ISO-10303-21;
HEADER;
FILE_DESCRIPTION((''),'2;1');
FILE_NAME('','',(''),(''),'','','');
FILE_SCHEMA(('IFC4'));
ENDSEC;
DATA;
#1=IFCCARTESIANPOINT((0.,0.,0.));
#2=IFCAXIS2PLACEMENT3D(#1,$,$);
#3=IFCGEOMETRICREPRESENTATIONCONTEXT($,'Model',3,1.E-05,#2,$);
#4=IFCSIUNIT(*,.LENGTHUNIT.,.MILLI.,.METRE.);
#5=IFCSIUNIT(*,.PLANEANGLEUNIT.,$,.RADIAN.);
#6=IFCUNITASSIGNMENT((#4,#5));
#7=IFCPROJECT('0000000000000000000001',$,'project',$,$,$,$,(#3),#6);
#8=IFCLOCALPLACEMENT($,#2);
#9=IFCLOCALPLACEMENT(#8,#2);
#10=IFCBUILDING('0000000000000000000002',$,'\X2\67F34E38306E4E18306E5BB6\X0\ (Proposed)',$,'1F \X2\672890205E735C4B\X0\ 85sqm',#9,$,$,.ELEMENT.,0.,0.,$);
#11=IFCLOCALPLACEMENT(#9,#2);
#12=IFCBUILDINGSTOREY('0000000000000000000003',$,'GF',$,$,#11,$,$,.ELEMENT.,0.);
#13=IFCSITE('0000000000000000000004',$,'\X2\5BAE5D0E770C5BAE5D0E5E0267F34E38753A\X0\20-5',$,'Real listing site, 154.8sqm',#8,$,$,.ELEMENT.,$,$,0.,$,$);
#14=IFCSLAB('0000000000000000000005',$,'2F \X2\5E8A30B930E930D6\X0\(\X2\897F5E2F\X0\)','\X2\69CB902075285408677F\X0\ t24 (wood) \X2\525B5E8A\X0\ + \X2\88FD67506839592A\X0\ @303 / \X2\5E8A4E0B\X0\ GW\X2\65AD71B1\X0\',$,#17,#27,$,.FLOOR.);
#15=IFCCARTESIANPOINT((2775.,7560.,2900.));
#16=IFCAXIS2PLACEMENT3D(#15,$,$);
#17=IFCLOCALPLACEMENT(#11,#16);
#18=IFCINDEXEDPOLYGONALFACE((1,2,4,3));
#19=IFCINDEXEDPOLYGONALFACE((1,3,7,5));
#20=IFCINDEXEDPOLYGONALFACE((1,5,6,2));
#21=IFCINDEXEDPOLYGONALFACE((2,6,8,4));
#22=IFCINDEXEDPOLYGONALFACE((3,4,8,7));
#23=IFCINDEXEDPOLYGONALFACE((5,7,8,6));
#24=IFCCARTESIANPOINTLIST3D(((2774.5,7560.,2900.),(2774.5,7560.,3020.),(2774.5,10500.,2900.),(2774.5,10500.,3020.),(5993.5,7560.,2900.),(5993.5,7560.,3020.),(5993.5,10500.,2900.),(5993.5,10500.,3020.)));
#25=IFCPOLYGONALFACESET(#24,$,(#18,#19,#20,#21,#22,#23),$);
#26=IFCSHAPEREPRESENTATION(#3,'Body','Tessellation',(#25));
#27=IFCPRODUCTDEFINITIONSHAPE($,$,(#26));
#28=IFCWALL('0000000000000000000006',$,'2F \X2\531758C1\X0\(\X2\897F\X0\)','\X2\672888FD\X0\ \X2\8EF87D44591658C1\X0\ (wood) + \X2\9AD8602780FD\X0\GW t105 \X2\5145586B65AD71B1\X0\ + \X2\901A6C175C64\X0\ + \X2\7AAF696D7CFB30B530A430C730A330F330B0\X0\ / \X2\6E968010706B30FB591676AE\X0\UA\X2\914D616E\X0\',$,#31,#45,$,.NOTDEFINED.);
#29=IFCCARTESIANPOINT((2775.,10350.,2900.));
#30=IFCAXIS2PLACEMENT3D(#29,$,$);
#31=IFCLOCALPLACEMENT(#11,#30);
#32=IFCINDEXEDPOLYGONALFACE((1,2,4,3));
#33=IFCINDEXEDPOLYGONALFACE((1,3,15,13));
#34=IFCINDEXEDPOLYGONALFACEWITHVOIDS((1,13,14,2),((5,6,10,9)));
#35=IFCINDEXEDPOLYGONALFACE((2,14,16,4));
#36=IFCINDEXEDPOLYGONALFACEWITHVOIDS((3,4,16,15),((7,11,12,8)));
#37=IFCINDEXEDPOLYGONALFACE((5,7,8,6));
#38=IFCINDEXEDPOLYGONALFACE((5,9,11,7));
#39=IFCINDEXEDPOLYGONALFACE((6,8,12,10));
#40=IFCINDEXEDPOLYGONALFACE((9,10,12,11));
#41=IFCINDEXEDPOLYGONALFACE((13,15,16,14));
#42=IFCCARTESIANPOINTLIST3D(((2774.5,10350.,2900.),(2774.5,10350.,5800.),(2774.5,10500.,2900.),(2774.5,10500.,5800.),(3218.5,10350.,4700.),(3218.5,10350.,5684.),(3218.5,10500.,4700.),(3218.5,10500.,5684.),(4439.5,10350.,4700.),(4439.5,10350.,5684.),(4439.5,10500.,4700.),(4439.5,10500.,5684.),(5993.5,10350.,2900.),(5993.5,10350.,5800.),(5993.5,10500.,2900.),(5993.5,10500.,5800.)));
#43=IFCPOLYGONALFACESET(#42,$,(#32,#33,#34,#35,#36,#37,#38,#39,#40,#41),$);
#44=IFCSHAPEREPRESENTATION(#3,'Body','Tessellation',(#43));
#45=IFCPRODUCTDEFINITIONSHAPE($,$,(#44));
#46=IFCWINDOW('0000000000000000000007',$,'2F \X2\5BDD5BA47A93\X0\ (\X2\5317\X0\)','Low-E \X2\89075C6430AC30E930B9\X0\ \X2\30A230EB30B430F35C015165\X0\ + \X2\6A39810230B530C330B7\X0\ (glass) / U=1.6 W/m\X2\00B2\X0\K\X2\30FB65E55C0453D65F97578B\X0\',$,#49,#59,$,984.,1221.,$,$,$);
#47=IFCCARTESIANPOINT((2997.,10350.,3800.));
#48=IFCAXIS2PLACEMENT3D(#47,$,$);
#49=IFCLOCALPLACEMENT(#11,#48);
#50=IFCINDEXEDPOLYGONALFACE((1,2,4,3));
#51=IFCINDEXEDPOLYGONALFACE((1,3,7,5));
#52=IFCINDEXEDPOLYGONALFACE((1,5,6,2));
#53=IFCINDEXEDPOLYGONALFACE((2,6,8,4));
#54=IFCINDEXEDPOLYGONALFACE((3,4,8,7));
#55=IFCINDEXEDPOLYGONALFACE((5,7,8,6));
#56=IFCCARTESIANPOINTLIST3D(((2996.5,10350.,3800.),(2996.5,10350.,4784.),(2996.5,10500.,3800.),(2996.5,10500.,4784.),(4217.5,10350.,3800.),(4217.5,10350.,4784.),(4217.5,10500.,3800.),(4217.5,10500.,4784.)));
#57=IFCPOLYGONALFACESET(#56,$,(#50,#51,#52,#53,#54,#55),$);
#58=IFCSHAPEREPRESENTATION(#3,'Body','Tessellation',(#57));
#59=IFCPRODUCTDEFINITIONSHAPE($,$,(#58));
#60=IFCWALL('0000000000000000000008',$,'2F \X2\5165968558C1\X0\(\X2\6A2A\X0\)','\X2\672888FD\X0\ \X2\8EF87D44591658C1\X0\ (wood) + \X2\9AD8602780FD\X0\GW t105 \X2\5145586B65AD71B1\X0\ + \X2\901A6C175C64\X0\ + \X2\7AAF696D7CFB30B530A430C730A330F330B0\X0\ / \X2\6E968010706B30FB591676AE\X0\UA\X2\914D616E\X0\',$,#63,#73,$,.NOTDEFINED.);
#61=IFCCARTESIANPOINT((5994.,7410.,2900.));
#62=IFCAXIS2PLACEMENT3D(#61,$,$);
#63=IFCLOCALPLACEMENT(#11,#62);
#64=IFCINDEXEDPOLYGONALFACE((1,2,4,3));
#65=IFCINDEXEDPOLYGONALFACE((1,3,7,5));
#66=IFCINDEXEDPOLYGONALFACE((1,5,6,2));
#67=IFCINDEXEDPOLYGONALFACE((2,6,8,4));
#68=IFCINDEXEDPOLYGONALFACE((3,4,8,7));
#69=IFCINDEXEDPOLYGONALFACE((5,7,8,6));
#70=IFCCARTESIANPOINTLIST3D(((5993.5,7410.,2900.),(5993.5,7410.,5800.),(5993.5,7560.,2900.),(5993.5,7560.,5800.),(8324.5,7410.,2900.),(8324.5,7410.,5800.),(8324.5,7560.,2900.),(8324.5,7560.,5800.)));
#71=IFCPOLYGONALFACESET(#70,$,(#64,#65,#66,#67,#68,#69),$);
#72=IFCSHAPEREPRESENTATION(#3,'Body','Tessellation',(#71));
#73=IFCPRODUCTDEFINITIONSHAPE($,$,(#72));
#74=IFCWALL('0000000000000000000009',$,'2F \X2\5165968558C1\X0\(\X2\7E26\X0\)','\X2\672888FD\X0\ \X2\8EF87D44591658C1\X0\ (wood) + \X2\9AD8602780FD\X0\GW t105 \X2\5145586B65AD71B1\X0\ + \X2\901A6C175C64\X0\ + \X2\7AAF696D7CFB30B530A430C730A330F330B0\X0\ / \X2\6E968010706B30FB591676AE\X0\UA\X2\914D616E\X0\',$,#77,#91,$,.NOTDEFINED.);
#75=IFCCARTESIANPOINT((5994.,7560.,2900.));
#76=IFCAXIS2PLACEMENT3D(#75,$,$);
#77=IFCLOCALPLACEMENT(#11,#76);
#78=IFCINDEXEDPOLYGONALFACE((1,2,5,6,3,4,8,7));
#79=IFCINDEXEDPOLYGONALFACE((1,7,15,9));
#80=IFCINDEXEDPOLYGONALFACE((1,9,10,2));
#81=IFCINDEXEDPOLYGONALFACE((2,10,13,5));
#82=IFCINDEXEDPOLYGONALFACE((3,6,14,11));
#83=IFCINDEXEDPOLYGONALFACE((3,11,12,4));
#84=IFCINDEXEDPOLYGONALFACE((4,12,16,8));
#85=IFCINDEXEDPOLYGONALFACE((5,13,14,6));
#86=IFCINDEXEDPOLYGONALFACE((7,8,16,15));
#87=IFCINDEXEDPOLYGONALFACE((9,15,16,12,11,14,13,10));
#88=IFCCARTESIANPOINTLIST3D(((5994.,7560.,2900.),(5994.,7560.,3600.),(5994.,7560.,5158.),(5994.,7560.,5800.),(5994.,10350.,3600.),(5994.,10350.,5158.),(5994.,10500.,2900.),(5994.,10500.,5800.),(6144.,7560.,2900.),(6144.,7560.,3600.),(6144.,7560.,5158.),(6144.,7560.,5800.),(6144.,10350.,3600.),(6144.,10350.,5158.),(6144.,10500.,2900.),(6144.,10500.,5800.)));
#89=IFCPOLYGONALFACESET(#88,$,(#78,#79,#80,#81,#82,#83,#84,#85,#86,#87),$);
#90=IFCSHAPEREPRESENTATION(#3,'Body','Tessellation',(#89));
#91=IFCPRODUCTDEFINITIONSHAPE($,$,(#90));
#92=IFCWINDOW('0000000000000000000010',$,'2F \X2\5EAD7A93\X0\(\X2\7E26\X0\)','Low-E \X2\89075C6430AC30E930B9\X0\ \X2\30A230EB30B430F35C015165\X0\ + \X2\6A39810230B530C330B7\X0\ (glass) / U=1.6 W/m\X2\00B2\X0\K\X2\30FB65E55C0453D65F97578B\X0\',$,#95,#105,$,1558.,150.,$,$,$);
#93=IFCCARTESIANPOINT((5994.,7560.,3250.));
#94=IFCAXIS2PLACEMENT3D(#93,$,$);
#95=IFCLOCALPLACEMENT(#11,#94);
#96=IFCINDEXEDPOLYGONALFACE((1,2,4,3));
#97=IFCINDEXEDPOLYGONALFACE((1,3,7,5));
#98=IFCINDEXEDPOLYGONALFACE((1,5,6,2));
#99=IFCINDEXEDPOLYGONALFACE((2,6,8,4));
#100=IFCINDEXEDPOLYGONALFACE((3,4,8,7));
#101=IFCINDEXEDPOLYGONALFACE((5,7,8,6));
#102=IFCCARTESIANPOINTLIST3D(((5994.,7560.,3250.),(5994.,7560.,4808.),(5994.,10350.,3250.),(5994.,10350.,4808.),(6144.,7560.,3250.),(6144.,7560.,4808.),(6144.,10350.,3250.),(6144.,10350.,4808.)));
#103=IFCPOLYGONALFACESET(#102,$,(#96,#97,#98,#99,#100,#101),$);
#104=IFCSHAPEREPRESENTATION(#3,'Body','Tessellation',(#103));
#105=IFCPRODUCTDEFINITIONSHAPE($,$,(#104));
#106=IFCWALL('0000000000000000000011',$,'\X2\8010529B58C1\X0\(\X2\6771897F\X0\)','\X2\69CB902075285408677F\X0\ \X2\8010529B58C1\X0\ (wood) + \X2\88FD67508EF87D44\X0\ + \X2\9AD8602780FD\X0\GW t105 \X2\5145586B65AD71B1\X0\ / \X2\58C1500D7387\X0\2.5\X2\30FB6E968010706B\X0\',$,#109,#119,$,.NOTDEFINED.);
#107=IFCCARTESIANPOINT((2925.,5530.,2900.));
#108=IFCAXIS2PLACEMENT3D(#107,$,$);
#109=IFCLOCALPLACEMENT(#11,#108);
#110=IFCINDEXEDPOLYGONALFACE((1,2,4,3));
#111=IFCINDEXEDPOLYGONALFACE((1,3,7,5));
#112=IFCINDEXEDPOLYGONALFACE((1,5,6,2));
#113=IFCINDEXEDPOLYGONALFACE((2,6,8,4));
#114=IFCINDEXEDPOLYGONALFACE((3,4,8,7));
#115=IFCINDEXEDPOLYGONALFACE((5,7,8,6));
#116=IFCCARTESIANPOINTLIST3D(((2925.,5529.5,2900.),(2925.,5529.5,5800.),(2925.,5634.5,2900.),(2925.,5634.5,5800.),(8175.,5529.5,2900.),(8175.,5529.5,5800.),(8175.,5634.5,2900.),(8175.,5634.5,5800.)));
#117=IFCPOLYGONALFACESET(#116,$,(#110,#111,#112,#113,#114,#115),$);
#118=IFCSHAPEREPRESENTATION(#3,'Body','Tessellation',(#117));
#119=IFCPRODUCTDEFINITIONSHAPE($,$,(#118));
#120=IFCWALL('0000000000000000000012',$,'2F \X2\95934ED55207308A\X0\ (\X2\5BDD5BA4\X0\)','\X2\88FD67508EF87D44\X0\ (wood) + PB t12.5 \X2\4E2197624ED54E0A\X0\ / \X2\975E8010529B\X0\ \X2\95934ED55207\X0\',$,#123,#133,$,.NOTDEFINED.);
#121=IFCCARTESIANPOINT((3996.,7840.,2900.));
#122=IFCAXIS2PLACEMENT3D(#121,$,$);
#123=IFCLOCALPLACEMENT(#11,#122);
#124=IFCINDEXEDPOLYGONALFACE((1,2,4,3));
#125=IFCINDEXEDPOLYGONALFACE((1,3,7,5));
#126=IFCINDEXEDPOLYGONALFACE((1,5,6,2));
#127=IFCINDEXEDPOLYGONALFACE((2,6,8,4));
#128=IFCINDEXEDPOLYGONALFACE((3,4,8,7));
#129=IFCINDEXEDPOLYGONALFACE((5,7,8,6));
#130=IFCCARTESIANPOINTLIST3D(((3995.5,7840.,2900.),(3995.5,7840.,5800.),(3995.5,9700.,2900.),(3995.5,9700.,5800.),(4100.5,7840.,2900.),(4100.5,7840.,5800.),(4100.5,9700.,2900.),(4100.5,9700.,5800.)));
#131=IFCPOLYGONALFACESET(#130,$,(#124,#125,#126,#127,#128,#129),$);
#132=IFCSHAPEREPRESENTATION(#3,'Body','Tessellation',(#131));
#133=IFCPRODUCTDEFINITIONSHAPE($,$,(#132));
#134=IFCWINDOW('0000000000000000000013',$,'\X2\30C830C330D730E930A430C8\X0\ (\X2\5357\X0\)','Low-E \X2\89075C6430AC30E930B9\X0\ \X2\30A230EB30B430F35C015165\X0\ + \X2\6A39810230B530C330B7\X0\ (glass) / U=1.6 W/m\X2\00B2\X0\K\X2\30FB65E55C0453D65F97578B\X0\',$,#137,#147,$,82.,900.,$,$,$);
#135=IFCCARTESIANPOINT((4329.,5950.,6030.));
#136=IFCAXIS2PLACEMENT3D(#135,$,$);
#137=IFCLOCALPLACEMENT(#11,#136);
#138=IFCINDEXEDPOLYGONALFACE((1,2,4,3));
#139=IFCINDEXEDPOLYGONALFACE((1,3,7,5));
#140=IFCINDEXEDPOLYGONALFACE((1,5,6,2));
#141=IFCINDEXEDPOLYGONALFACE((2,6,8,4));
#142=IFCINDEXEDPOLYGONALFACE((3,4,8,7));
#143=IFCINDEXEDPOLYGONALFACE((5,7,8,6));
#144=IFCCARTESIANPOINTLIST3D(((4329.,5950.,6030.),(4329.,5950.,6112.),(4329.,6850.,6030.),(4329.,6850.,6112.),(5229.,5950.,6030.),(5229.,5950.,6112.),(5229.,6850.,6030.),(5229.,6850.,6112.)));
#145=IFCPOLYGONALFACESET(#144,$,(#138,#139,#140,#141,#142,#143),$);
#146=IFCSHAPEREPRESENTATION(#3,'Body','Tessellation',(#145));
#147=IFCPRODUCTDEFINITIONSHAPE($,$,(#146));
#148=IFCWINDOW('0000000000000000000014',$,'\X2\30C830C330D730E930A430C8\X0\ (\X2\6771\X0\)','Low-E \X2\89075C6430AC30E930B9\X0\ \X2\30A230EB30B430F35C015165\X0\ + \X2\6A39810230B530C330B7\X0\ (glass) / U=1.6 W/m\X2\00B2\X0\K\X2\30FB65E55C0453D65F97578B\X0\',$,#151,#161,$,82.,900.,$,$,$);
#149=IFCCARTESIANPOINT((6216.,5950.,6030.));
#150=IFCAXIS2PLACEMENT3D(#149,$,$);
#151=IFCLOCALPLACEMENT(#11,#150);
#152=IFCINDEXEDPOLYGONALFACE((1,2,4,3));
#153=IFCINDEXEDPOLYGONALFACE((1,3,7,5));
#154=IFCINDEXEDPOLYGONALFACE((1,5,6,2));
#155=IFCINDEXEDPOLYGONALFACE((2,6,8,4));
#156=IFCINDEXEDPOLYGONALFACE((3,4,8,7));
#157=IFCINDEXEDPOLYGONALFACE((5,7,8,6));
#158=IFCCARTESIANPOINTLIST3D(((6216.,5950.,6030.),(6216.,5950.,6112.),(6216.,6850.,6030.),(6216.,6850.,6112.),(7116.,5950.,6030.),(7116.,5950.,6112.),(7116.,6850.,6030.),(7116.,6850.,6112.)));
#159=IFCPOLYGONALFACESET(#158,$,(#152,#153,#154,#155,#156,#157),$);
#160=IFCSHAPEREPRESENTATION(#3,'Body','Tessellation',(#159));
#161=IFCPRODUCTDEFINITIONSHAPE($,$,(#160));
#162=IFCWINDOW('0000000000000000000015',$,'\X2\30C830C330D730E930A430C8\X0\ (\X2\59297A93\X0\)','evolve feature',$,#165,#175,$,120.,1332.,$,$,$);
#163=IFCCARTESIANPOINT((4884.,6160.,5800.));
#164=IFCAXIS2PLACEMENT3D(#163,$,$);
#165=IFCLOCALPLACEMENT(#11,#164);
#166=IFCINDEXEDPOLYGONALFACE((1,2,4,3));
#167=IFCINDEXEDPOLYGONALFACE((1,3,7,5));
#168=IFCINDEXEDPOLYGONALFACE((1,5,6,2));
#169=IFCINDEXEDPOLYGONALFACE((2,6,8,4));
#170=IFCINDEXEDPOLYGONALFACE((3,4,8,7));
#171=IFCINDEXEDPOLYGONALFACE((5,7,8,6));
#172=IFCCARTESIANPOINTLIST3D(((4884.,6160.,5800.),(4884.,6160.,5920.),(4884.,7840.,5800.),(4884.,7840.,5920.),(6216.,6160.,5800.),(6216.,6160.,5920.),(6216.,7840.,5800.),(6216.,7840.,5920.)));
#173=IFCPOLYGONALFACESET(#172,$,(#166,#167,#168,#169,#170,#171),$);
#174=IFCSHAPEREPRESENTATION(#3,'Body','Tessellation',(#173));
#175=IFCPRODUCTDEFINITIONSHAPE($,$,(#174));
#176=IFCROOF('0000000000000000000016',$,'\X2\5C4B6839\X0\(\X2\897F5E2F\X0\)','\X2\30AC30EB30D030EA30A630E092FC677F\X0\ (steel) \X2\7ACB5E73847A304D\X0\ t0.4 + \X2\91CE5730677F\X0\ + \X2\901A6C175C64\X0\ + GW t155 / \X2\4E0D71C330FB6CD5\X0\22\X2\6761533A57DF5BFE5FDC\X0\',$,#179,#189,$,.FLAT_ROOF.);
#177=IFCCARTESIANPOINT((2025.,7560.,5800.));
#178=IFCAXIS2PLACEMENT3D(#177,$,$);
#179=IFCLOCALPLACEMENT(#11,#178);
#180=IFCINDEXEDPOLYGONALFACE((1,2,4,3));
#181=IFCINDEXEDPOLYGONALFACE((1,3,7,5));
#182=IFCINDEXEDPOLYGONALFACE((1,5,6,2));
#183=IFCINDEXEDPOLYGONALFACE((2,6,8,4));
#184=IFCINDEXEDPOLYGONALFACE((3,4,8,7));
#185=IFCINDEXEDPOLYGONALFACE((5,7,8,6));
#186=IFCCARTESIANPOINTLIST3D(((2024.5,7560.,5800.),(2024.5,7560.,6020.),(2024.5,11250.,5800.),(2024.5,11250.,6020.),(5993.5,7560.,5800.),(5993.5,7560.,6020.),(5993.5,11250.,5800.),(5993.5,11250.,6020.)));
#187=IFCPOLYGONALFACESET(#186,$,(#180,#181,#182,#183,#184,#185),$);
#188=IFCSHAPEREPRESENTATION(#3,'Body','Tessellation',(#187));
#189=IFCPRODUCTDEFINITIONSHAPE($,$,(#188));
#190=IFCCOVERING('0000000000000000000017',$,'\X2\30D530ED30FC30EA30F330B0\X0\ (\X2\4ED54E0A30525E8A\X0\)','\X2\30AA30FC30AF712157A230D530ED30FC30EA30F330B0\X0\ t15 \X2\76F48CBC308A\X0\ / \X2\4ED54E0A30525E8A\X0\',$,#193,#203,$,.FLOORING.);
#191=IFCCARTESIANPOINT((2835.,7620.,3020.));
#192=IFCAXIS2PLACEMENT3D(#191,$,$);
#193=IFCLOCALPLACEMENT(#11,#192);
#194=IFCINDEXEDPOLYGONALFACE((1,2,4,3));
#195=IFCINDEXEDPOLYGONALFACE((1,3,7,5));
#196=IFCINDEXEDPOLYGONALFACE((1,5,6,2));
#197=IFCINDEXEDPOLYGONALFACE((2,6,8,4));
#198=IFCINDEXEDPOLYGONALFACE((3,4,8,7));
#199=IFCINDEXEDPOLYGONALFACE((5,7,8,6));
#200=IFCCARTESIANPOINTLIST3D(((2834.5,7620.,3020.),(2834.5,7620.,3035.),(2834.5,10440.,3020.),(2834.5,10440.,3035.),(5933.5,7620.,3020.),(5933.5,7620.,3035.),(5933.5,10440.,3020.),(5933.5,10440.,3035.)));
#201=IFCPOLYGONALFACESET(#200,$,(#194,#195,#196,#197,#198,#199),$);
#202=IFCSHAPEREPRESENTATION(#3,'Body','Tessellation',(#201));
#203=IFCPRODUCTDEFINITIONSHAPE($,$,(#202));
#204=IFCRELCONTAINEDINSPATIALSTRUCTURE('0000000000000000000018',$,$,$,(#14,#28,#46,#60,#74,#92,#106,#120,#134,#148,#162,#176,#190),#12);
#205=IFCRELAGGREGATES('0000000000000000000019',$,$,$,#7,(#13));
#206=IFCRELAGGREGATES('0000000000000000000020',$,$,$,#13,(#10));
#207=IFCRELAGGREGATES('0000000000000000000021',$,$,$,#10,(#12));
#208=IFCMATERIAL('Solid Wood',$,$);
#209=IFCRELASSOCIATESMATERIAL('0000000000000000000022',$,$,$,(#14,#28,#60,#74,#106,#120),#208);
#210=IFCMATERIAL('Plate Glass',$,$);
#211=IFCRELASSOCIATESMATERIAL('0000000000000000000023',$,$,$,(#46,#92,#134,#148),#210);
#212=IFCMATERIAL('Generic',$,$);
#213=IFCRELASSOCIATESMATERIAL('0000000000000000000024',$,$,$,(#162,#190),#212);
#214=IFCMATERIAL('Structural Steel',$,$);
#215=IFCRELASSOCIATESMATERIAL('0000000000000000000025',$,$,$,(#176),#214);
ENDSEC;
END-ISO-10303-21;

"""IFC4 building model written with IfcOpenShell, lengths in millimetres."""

from ifc_helpers import new_model, si_unit, frame, frame_2d, origin, place, context, project, spatial, rectangle, extrude, material, element, fill, save


model = new_model("IFC4")

# Units and contexts
model_context = context("Model", 3, precision=1e-05, world=origin())
ifc_project = project(units=[si_unit("LENGTHUNIT", "METRE", prefix="MILLI"), si_unit("PLANEANGLEUNIT", "RADIAN")], contexts=[model_context])

# Site, building, storey
site_placement = place(None, origin())
site = spatial("IfcSite", under=ifc_project, at=site_placement, Name="宮崎県宮崎市柳丸町20-5", ObjectType="Real listing site, 154.8sqm", CompositionType="ELEMENT", RefElevation=0.0)
building_placement = place(site_placement, origin())
building = spatial("IfcBuilding", under=site, at=building_placement, Name="柳丸の丘の家 (Proposed)", ObjectType="1F 木造平屋 85sqm", CompositionType="ELEMENT", ElevationOfRefHeight=0.0, ElevationOfTerrain=0.0)
storey_placement = place(building_placement, origin())
storey = spatial("IfcBuildingStorey", under=building, at=storey_placement, Name="GF", CompositionType="ELEMENT", Elevation=0.0)

# Slab
ifc_material_1 = material(Name="Solid Wood")
slab_placement = place(storey_placement, frame((2775.0, 7560.0, 2900.0)))
element("IfcSlab", 1, at=slab_placement, inside=storey, material=ifc_material_1, Name="2F 床スラブ(西帯)", Description="構造用合板 t24 (wood) 剛床 + 製材根太 @303 / 床下 GW断熱", PredefinedType="FLOOR", context=model_context, shape_type="SweptSolid", body=[
    extrude(rectangle(XDim=3219.0, YDim=2940.0, at=frame_2d((1609.0, 1470.0))), frame((2775.0, 7560.0, 2900.0)), (0.0, 0.0, 1.0), 120.0),
])

# Wall, opening, window
wall_1_placement = place(storey_placement, frame((2775.0, 10350.0, 2900.0)))
wall_1 = element("IfcWall", 2, at=wall_1_placement, inside=storey, material=ifc_material_1, Name="2F 北壁(西)", Description="木製 軸組外壁 (wood) + 高性能GW t105 充填断熱 + 通気層 + 窯業系サイディング / 準耐火・外皮UA配慮", PredefinedType="NOTDEFINED", context=model_context, shape_type="SweptSolid", body=[
    extrude(rectangle(XDim=3219.0, YDim=150.0, at=frame_2d((1609.0, 75.0))), frame((2775.0, 10350.0, 2900.0)), (0.0, 0.0, 1.0), 2900.0),
])
opening_1_placement = place(storey_placement, frame((2997.0, 10350.0, 3800.0)))
opening_1 = element("IfcOpeningElement", 3, at=opening_1_placement, cuts=wall_1, PredefinedType="NOTDEFINED", context=model_context, shape_type="SweptSolid", body=[
    extrude(rectangle(XDim=1221.0, YDim=150.0, at=frame_2d((610.0, 75.0))), frame((2997.0, 10350.0, 3800.0)), (0.0, 0.0, 1.0), 984.0),
])
ifc_material_2 = material(Name="Plate Glass")
window_1_placement = place(storey_placement, frame((2997.0, 10350.0, 3800.0)))
window_1 = element("IfcWindow", 4, at=window_1_placement, inside=storey, material=ifc_material_2, Name="2F 寝室窓 (北)", Description="Low-E 複層ガラス アルゴン封入 + 樹脂サッシ (glass) / U=1.6 W/m²K・日射取得型", OverallHeight=984.0, OverallWidth=1221.0, context=model_context, shape_type="SweptSolid", body=[
    extrude(rectangle(XDim=1221.0, YDim=150.0, at=frame_2d((610.0, 75.0))), frame((2997.0, 10350.0, 3800.0)), (0.0, 0.0, 1.0), 984.0),
])
fill(opening_1, window_1)

# Wall
wall_2_placement = place(storey_placement, frame((5994.0, 7410.0, 2900.0)))
element("IfcWall", 5, at=wall_2_placement, inside=storey, material=ifc_material_1, Name="2F 入隅壁(横)", Description="木製 軸組外壁 (wood) + 高性能GW t105 充填断熱 + 通気層 + 窯業系サイディング / 準耐火・外皮UA配慮", PredefinedType="NOTDEFINED", context=model_context, shape_type="SweptSolid", body=[
    extrude(rectangle(XDim=2331.0, YDim=150.0, at=frame_2d((1165.0, 75.0))), frame((5994.0, 7410.0, 2900.0)), (0.0, 0.0, 1.0), 2900.0),
])

# Wall, opening, window
wall_3_placement = place(storey_placement, frame((5994.0, 7560.0, 2900.0)))
wall_3 = element("IfcWall", 6, at=wall_3_placement, inside=storey, material=ifc_material_1, Name="2F 入隅壁(縦)", Description="木製 軸組外壁 (wood) + 高性能GW t105 充填断熱 + 通気層 + 窯業系サイディング / 準耐火・外皮UA配慮", PredefinedType="NOTDEFINED", context=model_context, shape_type="SweptSolid", body=[
    extrude(rectangle(XDim=150.0, YDim=2940.0, at=frame_2d((75.0, 1470.0))), frame((5994.0, 7560.0, 2900.0)), (0.0, 0.0, 1.0), 2900.0),
])
opening_2_placement = place(storey_placement, frame((5994.0, 7560.0, 3250.0)))
opening_2 = element("IfcOpeningElement", 7, at=opening_2_placement, cuts=wall_3, PredefinedType="NOTDEFINED", context=model_context, shape_type="SweptSolid", body=[
    extrude(rectangle(XDim=150.0, YDim=2790.0, at=frame_2d((75.0, 1395.0))), frame((5994.0, 7560.0, 3250.0)), (0.0, 0.0, 1.0), 1558.0),
])
window_2_placement = place(storey_placement, frame((5994.0, 7560.0, 3250.0)))
window_2 = element("IfcWindow", 8, at=window_2_placement, inside=storey, material=ifc_material_2, Name="2F 庭窓(縦)", Description="Low-E 複層ガラス アルゴン封入 + 樹脂サッシ (glass) / U=1.6 W/m²K・日射取得型", OverallHeight=1558.0, OverallWidth=150.0, context=model_context, shape_type="SweptSolid", body=[
    extrude(rectangle(XDim=150.0, YDim=2790.0, at=frame_2d((75.0, 1395.0))), frame((5994.0, 7560.0, 3250.0)), (0.0, 0.0, 1.0), 1558.0),
])
fill(opening_2, window_2)

# Walls
wall_4_placement = place(storey_placement, frame((2925.0, 5530.0, 2900.0)))
element("IfcWall", 9, at=wall_4_placement, inside=storey, material=ifc_material_1, Name="耐力壁(東西)", Description="構造用合板 耐力壁 (wood) + 製材軸組 + 高性能GW t105 充填断熱 / 壁倍率2.5・準耐火", PredefinedType="NOTDEFINED", context=model_context, shape_type="SweptSolid", body=[
    extrude(rectangle(XDim=5250.0, YDim=105.0, at=frame_2d((2625.0, 52.0))), frame((2925.0, 5530.0, 2900.0)), (0.0, 0.0, 1.0), 2900.0),
])
wall_5_placement = place(storey_placement, frame((3996.0, 7840.0, 2900.0)))
element("IfcWall", 10, at=wall_5_placement, inside=storey, material=ifc_material_1, Name="2F 間仕切り (寝室)", Description="製材軸組 (wood) + PB t12.5 両面仕上 / 非耐力 間仕切", PredefinedType="NOTDEFINED", context=model_context, shape_type="SweptSolid", body=[
    extrude(rectangle(XDim=105.0, YDim=1860.0, at=frame_2d((52.0, 930.0))), frame((3996.0, 7840.0, 2900.0)), (0.0, 0.0, 1.0), 2900.0),
])

# Windows
window_3_placement = place(storey_placement, frame((4329.0, 5950.0, 6030.0)))
element("IfcWindow", 11, at=window_3_placement, inside=storey, material=ifc_material_2, Name="トップライト (南)", Description="Low-E 複層ガラス アルゴン封入 + 樹脂サッシ (glass) / U=1.6 W/m²K・日射取得型", OverallHeight=82.0, OverallWidth=900.0, context=model_context, shape_type="SweptSolid", body=[
    extrude(rectangle(XDim=900.0, YDim=900.0, at=frame_2d((450.0, 450.0))), frame((4329.0, 5950.0, 6030.0)), (0.0, 0.0, 1.0), 82.0),
])
window_4_placement = place(storey_placement, frame((6216.0, 5950.0, 6030.0)))
element("IfcWindow", 12, at=window_4_placement, inside=storey, material=ifc_material_2, Name="トップライト (東)", Description="Low-E 複層ガラス アルゴン封入 + 樹脂サッシ (glass) / U=1.6 W/m²K・日射取得型", OverallHeight=82.0, OverallWidth=900.0, context=model_context, shape_type="SweptSolid", body=[
    extrude(rectangle(XDim=900.0, YDim=900.0, at=frame_2d((450.0, 450.0))), frame((6216.0, 5950.0, 6030.0)), (0.0, 0.0, 1.0), 82.0),
])
ifc_material_3 = material(Name="Generic")
window_5_placement = place(storey_placement, frame((4884.0, 6160.0, 5800.0)))
element("IfcWindow", 13, at=window_5_placement, inside=storey, material=ifc_material_3, Name="トップライト (天窓)", Description="evolve feature", OverallHeight=120.0, OverallWidth=1332.0, context=model_context, shape_type="SweptSolid", body=[
    extrude(rectangle(XDim=1332.0, YDim=1680.0, at=frame_2d((666.0, 840.0))), frame((4884.0, 6160.0, 5800.0)), (0.0, 0.0, 1.0), 120.0),
])

# Roof
ifc_material_4 = material(Name="Structural Steel")
for number, where, name in (
    (14, (2025.0, 7560.0, 5800.0), "屋根(西帯)"),
):
    element("IfcRoof", number, at=place(storey_placement, frame(where)), inside=storey, material=ifc_material_4, Name=name, Description="ガルバリウム鋼板 (steel) 立平葺き t0.4 + 野地板 + 通気層 + GW t155 / 不燃・法22条区域対応", PredefinedType="FLAT_ROOF", context=model_context, shape_type="SweptSolid", body=[
        extrude(rectangle(XDim=3969.0, YDim=3690.0, at=frame_2d((1984.0, 1845.0))), frame((2025.0, 7560.0, 5800.0)), (0.0, 0.0, 1.0), 220.0),
    ])

# Covering
covering_placement = place(storey_placement, frame((2835.0, 7620.0, 3020.0)))
element("IfcCovering", 15, at=covering_placement, inside=storey, material=ifc_material_3, Name="フローリング (仕上げ床)", Description="オーク無垢フローリング t15 直貼り / 仕上げ床", PredefinedType="FLOORING", context=model_context, shape_type="SweptSolid", body=[
    extrude(rectangle(XDim=3099.0, YDim=2820.0, at=frame_2d((1549.0, 1410.0))), frame((2835.0, 7620.0, 3020.0)), (0.0, 0.0, 1.0), 15.0),
])

save(model, "model.ifc")
